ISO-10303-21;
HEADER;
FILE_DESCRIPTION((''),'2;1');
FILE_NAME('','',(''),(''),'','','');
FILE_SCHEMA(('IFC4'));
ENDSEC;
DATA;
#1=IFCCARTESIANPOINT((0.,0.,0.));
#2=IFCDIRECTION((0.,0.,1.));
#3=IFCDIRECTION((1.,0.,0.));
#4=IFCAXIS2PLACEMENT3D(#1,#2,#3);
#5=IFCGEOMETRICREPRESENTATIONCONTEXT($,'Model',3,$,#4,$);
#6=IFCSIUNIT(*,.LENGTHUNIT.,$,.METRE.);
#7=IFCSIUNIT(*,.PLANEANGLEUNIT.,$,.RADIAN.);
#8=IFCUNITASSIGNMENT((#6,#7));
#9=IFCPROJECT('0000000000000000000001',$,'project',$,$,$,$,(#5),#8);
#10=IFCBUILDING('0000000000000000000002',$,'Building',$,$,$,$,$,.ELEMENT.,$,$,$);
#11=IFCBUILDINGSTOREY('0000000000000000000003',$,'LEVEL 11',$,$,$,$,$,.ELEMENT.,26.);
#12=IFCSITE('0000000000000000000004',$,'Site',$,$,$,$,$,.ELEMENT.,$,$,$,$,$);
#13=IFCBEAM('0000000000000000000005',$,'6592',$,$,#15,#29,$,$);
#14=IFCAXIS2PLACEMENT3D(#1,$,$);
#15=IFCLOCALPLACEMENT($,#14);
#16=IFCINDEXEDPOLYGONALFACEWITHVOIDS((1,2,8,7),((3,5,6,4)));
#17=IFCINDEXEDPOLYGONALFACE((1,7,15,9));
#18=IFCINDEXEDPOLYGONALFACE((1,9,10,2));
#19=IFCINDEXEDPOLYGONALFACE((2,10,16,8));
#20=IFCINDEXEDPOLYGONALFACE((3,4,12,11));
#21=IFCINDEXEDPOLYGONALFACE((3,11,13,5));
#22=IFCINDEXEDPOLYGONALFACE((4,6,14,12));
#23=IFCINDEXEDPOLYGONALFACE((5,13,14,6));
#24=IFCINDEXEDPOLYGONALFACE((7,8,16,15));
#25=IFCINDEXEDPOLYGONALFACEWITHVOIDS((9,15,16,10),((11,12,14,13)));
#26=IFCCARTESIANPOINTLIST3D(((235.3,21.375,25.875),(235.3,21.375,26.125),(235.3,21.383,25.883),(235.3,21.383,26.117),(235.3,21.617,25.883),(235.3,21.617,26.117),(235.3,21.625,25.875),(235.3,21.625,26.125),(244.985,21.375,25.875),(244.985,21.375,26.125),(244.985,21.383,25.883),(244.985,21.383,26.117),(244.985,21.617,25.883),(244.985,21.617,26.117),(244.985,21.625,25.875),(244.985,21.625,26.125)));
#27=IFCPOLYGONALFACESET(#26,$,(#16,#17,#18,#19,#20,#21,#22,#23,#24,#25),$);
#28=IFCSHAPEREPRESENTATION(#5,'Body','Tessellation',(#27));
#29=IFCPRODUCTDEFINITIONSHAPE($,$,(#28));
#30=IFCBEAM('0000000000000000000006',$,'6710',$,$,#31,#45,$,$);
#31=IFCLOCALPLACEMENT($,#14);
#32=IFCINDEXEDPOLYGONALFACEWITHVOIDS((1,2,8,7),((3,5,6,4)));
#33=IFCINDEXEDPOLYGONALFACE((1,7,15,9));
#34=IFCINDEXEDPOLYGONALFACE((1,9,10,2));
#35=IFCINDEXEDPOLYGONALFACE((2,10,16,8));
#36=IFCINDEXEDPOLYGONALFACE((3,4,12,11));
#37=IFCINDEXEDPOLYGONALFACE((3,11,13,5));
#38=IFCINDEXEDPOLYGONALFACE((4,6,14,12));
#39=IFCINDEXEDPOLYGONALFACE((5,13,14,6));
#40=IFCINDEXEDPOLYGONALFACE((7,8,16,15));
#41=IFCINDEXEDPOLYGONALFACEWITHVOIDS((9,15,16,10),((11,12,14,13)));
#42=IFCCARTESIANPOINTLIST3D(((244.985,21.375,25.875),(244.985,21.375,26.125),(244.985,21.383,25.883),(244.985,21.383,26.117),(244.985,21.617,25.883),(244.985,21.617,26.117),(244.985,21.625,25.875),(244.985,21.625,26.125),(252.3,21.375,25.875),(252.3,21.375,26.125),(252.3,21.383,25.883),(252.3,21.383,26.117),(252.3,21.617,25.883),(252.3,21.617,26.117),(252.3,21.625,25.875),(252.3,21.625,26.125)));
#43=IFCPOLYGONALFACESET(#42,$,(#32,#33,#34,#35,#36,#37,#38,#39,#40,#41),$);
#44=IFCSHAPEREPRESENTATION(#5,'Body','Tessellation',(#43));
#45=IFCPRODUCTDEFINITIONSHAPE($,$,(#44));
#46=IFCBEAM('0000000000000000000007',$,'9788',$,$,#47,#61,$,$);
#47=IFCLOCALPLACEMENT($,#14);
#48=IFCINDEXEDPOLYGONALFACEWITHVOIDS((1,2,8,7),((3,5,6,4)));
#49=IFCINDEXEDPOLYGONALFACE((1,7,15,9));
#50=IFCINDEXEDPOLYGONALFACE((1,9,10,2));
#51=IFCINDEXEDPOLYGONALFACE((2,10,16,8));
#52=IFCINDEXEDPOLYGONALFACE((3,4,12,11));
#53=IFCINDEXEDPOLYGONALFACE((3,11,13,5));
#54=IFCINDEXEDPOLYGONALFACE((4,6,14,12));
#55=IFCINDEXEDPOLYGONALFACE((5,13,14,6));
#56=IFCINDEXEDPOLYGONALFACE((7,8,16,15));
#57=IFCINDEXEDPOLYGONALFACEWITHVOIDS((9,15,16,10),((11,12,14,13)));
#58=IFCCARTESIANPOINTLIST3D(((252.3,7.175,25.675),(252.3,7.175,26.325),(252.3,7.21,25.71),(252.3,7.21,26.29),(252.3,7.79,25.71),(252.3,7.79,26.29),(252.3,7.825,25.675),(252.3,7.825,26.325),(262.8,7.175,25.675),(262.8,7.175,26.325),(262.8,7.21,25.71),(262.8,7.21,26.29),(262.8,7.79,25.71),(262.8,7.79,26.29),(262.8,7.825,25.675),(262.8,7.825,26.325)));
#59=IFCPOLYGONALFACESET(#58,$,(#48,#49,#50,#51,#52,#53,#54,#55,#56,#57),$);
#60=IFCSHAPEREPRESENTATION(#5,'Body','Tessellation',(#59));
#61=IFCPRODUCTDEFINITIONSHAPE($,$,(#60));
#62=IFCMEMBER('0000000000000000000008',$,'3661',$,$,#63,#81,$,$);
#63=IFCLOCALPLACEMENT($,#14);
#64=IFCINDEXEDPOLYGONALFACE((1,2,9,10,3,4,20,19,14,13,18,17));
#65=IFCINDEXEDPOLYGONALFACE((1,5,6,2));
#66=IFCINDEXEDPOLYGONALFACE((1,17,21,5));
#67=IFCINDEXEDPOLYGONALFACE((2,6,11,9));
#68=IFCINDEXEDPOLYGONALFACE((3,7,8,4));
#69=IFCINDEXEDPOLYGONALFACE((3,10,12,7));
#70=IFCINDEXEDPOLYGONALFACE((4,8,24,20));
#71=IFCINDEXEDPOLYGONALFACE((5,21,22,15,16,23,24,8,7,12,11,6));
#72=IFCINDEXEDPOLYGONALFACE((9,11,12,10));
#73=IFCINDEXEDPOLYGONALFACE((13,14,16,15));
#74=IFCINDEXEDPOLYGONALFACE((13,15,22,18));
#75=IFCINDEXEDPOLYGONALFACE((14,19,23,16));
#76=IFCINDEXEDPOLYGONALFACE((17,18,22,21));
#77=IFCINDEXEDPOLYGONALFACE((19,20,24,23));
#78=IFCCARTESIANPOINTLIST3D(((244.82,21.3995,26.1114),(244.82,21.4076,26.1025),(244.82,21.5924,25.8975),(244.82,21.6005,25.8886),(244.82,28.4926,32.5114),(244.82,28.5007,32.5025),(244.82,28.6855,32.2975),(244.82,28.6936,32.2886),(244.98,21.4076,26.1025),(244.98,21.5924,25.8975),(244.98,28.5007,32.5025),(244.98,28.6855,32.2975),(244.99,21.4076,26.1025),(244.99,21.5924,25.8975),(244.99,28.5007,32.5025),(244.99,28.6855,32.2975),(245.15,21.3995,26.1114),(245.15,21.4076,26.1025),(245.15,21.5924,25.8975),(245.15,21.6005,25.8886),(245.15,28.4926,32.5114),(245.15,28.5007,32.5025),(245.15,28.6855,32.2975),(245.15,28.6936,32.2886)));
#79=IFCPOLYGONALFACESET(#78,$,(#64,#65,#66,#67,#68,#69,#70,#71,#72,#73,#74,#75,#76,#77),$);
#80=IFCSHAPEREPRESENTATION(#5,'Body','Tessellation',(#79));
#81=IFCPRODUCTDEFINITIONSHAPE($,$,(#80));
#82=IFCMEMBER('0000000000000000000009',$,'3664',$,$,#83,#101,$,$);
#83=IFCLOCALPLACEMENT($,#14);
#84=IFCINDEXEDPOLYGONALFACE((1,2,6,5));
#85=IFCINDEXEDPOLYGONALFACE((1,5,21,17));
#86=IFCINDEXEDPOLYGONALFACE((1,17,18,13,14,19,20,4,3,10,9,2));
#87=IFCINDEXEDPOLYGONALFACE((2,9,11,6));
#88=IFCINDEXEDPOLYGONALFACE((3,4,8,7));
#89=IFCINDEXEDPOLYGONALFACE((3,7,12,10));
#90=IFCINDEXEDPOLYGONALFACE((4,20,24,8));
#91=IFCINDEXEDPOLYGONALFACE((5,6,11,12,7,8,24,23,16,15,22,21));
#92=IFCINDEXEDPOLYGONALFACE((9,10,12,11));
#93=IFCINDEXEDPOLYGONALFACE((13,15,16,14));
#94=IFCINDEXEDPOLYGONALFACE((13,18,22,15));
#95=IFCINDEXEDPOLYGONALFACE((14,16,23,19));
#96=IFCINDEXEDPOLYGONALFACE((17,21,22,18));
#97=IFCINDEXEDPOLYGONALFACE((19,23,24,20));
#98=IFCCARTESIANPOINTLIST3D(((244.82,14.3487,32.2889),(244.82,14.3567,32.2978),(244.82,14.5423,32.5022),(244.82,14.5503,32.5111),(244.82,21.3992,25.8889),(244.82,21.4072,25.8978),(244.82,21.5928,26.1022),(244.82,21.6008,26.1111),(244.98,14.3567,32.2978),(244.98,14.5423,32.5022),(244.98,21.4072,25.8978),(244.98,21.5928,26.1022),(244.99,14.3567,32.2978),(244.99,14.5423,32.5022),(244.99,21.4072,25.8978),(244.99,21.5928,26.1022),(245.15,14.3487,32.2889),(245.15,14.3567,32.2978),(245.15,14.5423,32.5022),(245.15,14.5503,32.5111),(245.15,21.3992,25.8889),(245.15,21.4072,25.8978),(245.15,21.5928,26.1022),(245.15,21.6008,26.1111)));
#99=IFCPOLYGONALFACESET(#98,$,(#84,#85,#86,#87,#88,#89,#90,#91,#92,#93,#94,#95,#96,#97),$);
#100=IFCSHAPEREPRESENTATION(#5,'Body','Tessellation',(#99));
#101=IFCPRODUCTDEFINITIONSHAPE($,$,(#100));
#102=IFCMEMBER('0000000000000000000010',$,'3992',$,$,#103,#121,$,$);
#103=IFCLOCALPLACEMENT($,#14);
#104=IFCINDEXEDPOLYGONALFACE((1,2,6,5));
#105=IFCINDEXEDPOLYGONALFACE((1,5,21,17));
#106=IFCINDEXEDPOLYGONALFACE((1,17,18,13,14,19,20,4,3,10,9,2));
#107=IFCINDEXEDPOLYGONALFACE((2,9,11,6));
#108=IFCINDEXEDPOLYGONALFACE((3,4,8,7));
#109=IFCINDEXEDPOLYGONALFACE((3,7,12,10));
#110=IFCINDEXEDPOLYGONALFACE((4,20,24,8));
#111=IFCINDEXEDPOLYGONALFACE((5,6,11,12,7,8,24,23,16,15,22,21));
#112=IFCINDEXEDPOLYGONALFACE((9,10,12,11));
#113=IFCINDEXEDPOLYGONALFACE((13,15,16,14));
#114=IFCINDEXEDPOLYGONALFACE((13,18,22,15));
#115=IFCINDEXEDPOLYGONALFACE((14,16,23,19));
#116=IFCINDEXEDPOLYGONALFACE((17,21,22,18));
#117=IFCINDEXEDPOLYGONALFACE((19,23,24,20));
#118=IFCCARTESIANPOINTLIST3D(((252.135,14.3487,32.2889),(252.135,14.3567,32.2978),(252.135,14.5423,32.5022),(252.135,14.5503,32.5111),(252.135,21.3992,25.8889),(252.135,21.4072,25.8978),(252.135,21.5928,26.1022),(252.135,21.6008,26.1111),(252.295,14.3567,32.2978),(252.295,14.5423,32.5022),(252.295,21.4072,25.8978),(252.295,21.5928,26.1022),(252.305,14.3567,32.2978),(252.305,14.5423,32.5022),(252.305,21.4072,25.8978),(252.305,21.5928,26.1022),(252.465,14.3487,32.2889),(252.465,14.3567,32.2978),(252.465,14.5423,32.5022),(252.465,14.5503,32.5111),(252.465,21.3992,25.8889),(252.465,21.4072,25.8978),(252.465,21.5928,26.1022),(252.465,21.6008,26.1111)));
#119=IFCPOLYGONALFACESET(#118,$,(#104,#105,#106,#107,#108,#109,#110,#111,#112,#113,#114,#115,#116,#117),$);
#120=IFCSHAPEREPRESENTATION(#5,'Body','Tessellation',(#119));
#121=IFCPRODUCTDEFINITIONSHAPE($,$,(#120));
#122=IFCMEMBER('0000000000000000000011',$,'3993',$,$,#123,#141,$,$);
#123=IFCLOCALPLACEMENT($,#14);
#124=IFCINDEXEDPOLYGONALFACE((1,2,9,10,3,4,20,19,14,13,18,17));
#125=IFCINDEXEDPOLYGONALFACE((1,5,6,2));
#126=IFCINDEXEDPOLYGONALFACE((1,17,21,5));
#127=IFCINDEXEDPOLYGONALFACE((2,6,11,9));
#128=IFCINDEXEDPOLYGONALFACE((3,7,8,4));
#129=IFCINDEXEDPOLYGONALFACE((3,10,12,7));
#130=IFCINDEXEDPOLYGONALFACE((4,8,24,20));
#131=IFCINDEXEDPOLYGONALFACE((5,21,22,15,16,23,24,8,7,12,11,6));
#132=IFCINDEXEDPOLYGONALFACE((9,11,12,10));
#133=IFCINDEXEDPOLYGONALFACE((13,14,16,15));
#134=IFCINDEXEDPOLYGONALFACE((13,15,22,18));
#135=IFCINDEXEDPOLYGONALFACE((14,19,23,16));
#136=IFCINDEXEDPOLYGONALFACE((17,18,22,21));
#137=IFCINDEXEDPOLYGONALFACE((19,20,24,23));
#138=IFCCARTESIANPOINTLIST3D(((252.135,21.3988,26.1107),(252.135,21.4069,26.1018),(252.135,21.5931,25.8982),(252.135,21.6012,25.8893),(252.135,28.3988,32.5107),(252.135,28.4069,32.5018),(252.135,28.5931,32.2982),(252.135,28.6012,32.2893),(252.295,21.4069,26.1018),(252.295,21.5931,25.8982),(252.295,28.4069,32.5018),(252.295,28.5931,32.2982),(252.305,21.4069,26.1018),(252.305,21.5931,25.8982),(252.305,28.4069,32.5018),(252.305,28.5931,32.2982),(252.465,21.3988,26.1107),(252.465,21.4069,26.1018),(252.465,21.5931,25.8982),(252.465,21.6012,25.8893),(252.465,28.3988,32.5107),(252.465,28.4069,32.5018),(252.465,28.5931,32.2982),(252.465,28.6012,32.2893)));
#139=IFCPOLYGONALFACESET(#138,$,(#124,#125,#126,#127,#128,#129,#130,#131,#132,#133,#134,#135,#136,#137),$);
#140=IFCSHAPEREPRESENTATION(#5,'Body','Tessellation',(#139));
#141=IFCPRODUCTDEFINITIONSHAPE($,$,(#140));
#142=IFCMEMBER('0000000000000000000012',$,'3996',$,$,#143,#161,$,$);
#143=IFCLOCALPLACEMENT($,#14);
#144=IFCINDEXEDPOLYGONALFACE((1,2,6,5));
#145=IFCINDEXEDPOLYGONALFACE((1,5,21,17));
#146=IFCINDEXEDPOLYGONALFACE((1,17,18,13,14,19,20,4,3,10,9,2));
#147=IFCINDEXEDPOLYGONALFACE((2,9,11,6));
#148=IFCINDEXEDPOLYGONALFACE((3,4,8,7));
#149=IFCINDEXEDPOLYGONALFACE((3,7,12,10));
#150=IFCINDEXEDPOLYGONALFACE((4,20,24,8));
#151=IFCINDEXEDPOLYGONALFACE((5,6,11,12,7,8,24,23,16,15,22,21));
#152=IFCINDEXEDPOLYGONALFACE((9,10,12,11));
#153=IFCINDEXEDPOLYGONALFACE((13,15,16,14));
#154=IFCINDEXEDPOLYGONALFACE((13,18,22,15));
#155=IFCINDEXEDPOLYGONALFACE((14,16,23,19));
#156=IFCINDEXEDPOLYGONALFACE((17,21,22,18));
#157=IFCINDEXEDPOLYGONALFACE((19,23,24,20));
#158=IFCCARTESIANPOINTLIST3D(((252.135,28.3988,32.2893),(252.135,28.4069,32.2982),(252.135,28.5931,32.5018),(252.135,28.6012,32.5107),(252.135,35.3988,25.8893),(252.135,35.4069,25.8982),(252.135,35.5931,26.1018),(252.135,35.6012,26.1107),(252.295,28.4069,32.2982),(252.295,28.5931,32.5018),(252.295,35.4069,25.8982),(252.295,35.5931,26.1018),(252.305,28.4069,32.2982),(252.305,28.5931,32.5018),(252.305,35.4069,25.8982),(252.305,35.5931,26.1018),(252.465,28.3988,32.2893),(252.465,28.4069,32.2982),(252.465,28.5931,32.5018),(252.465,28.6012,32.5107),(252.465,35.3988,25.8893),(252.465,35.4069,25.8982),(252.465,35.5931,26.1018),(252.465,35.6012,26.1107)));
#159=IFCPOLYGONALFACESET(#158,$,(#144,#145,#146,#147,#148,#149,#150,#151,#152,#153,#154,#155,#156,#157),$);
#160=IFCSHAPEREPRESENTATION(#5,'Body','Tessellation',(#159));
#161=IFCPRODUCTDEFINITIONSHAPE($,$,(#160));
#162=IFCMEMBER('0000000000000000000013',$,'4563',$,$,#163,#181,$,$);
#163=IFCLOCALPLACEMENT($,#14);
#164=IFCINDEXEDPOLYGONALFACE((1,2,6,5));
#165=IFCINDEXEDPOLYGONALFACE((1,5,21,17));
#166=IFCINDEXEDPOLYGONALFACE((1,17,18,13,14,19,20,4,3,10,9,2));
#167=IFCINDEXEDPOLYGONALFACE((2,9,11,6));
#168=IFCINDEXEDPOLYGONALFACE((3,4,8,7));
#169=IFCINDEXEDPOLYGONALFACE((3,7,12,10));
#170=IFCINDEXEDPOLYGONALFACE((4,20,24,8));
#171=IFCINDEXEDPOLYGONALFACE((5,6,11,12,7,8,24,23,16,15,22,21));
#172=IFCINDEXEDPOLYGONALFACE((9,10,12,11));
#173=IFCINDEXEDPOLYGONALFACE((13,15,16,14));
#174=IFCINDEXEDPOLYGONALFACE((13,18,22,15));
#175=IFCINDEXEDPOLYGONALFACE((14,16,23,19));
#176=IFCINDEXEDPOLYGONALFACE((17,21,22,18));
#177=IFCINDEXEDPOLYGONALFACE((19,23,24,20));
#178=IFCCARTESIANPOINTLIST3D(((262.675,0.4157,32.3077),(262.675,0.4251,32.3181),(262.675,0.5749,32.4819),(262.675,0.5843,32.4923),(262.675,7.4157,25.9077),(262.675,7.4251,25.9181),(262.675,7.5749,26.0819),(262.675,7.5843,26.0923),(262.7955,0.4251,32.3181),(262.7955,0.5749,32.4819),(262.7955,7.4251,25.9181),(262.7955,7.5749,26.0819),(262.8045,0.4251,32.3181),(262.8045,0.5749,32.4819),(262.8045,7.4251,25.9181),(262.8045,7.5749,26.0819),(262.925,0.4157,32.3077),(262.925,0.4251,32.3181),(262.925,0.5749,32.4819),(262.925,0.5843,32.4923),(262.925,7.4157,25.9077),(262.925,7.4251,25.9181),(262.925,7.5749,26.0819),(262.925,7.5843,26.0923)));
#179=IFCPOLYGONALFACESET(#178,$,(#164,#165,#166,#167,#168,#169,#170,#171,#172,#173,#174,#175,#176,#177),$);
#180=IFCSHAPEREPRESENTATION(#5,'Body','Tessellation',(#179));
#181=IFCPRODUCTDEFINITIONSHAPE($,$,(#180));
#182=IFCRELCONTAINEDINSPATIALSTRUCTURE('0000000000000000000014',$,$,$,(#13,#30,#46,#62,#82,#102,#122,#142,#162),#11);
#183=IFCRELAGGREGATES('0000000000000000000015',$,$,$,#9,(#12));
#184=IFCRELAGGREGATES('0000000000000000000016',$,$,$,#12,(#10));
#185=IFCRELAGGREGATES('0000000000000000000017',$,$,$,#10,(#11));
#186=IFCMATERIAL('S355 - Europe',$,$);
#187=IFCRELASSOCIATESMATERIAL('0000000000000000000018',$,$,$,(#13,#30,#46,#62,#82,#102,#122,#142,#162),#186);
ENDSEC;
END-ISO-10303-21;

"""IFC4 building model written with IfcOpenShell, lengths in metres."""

from ifc_helpers import new_model, si_unit, frame, origin_with_axes, origin_2d_with_axis, place, context, project, spatial, hollow_rectangle, i_section, extrude, material, material_profile, profile_set, profile_usage, element, save


model = new_model("IFC4")

# Units and contexts
model_context = context("Model", 3, world=origin_with_axes())
ifc_project = project(units=[si_unit("LENGTHUNIT", "METRE"), si_unit("PLANEANGLEUNIT", "RADIAN")], contexts=[model_context])

# Site, building, storey
site = spatial("IfcSite", under=ifc_project, Name="Site", CompositionType="ELEMENT")
building = spatial("IfcBuilding", under=site, Name="Building", CompositionType="ELEMENT")
storey = spatial("IfcBuildingStorey", under=building, Name="LEVEL 11", CompositionType="ELEMENT", Elevation=26.0)

# Shared definitions
ifc_material = material(Name="S355 - Europe")

# Beams
ifc_material_profile_1 = material_profile(ifc_material, hollow_rectangle(XDim=0.25, YDim=0.25, WallThickness=0.008, at=origin_2d_with_axis()))
ifc_profile_set_1 = profile_set([ifc_material_profile_1])
ifc_profile_usage_1 = profile_usage(ifc_profile_set_1, cardinal=10)
beam_1_placement = place(None, frame((244.985, 21.5, 26.0), z_axis=(-1.0, 0.0, 0.0), x_axis=(0.0, -1.0, 0.0)))
element("IfcBeam", 1, at=beam_1_placement, inside=storey, material=ifc_profile_usage_1, Name="6592", context=model_context, shape_type="SweptSolid", body=[
    extrude(hollow_rectangle(XDim=0.25, YDim=0.25, WallThickness=0.008, at=origin_2d_with_axis()), origin_with_axes(), (0.0, 0.0, 1.0), 9.685),
])
ifc_material_profile_2 = material_profile(ifc_material, hollow_rectangle(XDim=0.25, YDim=0.25, WallThickness=0.008, at=origin_2d_with_axis()))
ifc_profile_set_2 = profile_set([ifc_material_profile_2])
ifc_profile_usage_2 = profile_usage(ifc_profile_set_2, cardinal=10)
beam_2_placement = place(None, frame((252.3, 21.5, 26.0), z_axis=(-1.0, 0.0, 0.0), x_axis=(0.0, -1.0, 0.0)))
element("IfcBeam", 2, at=beam_2_placement, inside=storey, material=ifc_profile_usage_2, Name="6710", context=model_context, shape_type="SweptSolid", body=[
    extrude(hollow_rectangle(XDim=0.25, YDim=0.25, WallThickness=0.008, at=origin_2d_with_axis()), origin_with_axes(), (0.0, 0.0, 1.0), 7.315),
])
ifc_material_profile_3 = material_profile(ifc_material, hollow_rectangle(XDim=0.65, YDim=0.65, WallThickness=0.035, at=origin_2d_with_axis()))
ifc_profile_set_3 = profile_set([ifc_material_profile_3])
ifc_profile_usage_3 = profile_usage(ifc_profile_set_3, cardinal=10)
beam_3_placement = place(None, frame((262.8, 7.5, 26.0), z_axis=(-1.0, 0.0, 0.0), x_axis=(0.0, -1.0, 0.0)))
element("IfcBeam", 3, at=beam_3_placement, inside=storey, material=ifc_profile_usage_3, Name="9788", context=model_context, shape_type="SweptSolid", body=[
    extrude(hollow_rectangle(XDim=0.65, YDim=0.65, WallThickness=0.035, at=origin_2d_with_axis()), origin_with_axes(), (0.0, 0.0, 1.0), 10.5),
])

# Members
ifc_material_profile_4 = material_profile(ifc_material, i_section(OverallWidth=0.33, OverallDepth=0.3, WebThickness=0.01, FlangeThickness=0.012, at=origin_2d_with_axis()))
ifc_profile_set_4 = profile_set([ifc_material_profile_4])
ifc_profile_usage_4 = profile_usage(ifc_profile_set_4, cardinal=10)
member_1_placement = place(None, frame((244.985, 21.5, 26.0), z_axis=(0.0, 0.74245, 0.669902), x_axis=(-1.0, 0.0, 0.0)))
element("IfcMember", 4, at=member_1_placement, inside=storey, material=ifc_profile_usage_4, Name="3661", context=model_context, shape_type="SweptSolid", body=[
    extrude(i_section(OverallWidth=0.33, OverallDepth=0.3, WebThickness=0.01, FlangeThickness=0.012, at=origin_2d_with_axis()), origin_with_axes(), (0.0, 0.0, 1.0), 9.5536),
])
ifc_material_profile_5 = material_profile(ifc_material, i_section(OverallWidth=0.33, OverallDepth=0.3, WebThickness=0.01, FlangeThickness=0.012, at=origin_2d_with_axis()))
ifc_profile_set_5 = profile_set([ifc_material_profile_5])
ifc_profile_usage_5 = profile_usage(ifc_profile_set_5, cardinal=10)
member_2_placement = place(None, frame((244.985, 14.4495, 32.4), z_axis=(0.0, 0.740439, -0.672124), x_axis=(-1.0, 0.0, 0.0)))
element("IfcMember", 5, at=member_2_placement, inside=storey, material=ifc_profile_usage_5, Name="3664", context=model_context, shape_type="SweptSolid", body=[
    extrude(i_section(OverallWidth=0.33, OverallDepth=0.3, WebThickness=0.01, FlangeThickness=0.012, at=origin_2d_with_axis()), origin_with_axes(), (0.0, 0.0, 1.0), 9.5221),
])
ifc_material_profile_6 = material_profile(ifc_material, i_section(OverallWidth=0.33, OverallDepth=0.3, WebThickness=0.01, FlangeThickness=0.012, at=origin_2d_with_axis()))
ifc_profile_set_6 = profile_set([ifc_material_profile_6])
ifc_profile_usage_6 = profile_usage(ifc_profile_set_6, cardinal=10)
member_3_placement = place(None, frame((252.3, 14.4495, 32.4), z_axis=(0.0, 0.740439, -0.672124), x_axis=(-1.0, 0.0, 0.0)))
element("IfcMember", 6, at=member_3_placement, inside=storey, material=ifc_profile_usage_6, Name="3992", context=model_context, shape_type="SweptSolid", body=[
    extrude(i_section(OverallWidth=0.33, OverallDepth=0.3, WebThickness=0.01, FlangeThickness=0.012, at=origin_2d_with_axis()), origin_with_axes(), (0.0, 0.0, 1.0), 9.5221),
])
ifc_material_profile_7 = material_profile(ifc_material, i_section(OverallWidth=0.33, OverallDepth=0.3, WebThickness=0.01, FlangeThickness=0.012, at=origin_2d_with_axis()))
ifc_profile_set_7 = profile_set([ifc_material_profile_7])
ifc_profile_usage_7 = profile_usage(ifc_profile_set_7, cardinal=10)
member_4_placement = place(None, frame((252.3, 21.5, 26.0), z_axis=(0.0, 0.738029, 0.674769), x_axis=(-1.0, 0.0, 0.0)))
element("IfcMember", 7, at=member_4_placement, inside=storey, material=ifc_profile_usage_7, Name="3993", context=model_context, shape_type="SweptSolid", body=[
    extrude(i_section(OverallWidth=0.33, OverallDepth=0.3, WebThickness=0.01, FlangeThickness=0.012, at=origin_2d_with_axis()), origin_with_axes(), (0.0, 0.0, 1.0), 9.4847),
])
ifc_material_profile_8 = material_profile(ifc_material, i_section(OverallWidth=0.33, OverallDepth=0.3, WebThickness=0.01, FlangeThickness=0.012, at=origin_2d_with_axis()))
ifc_profile_set_8 = profile_set([ifc_material_profile_8])
ifc_profile_usage_8 = profile_usage(ifc_profile_set_8, cardinal=10)
member_5_placement = place(None, frame((252.3, 28.5, 32.4), z_axis=(0.0, 0.738029, -0.674769), x_axis=(-1.0, 0.0, 0.0)))
element("IfcMember", 8, at=member_5_placement, inside=storey, material=ifc_profile_usage_8, Name="3996", context=model_context, shape_type="SweptSolid", body=[
    extrude(i_section(OverallWidth=0.33, OverallDepth=0.3, WebThickness=0.01, FlangeThickness=0.012, at=origin_2d_with_axis()), origin_with_axes(), (0.0, 0.0, 1.0), 9.4847),
])
ifc_material_profile_9 = material_profile(ifc_material, i_section(OverallWidth=0.25, OverallDepth=0.25, WebThickness=0.009, FlangeThickness=0.014, at=origin_2d_with_axis()))
ifc_profile_set_9 = profile_set([ifc_material_profile_9])
ifc_profile_usage_9 = profile_usage(ifc_profile_set_9, cardinal=10)
member_6_placement = place(None, frame((262.8, 7.5, 26.0), z_axis=(0.0, -0.738029, 0.674769), x_axis=(1.0, 0.0, 0.0)))
element("IfcMember", 9, at=member_6_placement, inside=storey, material=ifc_profile_usage_9, Name="4563", context=model_context, shape_type="SweptSolid", body=[
    extrude(i_section(OverallWidth=0.25, OverallDepth=0.25, WebThickness=0.009, FlangeThickness=0.014, at=origin_2d_with_axis()), origin_with_axes(), (0.0, 0.0, 1.0), 9.4847),
])

save(model, "model.ifc")
